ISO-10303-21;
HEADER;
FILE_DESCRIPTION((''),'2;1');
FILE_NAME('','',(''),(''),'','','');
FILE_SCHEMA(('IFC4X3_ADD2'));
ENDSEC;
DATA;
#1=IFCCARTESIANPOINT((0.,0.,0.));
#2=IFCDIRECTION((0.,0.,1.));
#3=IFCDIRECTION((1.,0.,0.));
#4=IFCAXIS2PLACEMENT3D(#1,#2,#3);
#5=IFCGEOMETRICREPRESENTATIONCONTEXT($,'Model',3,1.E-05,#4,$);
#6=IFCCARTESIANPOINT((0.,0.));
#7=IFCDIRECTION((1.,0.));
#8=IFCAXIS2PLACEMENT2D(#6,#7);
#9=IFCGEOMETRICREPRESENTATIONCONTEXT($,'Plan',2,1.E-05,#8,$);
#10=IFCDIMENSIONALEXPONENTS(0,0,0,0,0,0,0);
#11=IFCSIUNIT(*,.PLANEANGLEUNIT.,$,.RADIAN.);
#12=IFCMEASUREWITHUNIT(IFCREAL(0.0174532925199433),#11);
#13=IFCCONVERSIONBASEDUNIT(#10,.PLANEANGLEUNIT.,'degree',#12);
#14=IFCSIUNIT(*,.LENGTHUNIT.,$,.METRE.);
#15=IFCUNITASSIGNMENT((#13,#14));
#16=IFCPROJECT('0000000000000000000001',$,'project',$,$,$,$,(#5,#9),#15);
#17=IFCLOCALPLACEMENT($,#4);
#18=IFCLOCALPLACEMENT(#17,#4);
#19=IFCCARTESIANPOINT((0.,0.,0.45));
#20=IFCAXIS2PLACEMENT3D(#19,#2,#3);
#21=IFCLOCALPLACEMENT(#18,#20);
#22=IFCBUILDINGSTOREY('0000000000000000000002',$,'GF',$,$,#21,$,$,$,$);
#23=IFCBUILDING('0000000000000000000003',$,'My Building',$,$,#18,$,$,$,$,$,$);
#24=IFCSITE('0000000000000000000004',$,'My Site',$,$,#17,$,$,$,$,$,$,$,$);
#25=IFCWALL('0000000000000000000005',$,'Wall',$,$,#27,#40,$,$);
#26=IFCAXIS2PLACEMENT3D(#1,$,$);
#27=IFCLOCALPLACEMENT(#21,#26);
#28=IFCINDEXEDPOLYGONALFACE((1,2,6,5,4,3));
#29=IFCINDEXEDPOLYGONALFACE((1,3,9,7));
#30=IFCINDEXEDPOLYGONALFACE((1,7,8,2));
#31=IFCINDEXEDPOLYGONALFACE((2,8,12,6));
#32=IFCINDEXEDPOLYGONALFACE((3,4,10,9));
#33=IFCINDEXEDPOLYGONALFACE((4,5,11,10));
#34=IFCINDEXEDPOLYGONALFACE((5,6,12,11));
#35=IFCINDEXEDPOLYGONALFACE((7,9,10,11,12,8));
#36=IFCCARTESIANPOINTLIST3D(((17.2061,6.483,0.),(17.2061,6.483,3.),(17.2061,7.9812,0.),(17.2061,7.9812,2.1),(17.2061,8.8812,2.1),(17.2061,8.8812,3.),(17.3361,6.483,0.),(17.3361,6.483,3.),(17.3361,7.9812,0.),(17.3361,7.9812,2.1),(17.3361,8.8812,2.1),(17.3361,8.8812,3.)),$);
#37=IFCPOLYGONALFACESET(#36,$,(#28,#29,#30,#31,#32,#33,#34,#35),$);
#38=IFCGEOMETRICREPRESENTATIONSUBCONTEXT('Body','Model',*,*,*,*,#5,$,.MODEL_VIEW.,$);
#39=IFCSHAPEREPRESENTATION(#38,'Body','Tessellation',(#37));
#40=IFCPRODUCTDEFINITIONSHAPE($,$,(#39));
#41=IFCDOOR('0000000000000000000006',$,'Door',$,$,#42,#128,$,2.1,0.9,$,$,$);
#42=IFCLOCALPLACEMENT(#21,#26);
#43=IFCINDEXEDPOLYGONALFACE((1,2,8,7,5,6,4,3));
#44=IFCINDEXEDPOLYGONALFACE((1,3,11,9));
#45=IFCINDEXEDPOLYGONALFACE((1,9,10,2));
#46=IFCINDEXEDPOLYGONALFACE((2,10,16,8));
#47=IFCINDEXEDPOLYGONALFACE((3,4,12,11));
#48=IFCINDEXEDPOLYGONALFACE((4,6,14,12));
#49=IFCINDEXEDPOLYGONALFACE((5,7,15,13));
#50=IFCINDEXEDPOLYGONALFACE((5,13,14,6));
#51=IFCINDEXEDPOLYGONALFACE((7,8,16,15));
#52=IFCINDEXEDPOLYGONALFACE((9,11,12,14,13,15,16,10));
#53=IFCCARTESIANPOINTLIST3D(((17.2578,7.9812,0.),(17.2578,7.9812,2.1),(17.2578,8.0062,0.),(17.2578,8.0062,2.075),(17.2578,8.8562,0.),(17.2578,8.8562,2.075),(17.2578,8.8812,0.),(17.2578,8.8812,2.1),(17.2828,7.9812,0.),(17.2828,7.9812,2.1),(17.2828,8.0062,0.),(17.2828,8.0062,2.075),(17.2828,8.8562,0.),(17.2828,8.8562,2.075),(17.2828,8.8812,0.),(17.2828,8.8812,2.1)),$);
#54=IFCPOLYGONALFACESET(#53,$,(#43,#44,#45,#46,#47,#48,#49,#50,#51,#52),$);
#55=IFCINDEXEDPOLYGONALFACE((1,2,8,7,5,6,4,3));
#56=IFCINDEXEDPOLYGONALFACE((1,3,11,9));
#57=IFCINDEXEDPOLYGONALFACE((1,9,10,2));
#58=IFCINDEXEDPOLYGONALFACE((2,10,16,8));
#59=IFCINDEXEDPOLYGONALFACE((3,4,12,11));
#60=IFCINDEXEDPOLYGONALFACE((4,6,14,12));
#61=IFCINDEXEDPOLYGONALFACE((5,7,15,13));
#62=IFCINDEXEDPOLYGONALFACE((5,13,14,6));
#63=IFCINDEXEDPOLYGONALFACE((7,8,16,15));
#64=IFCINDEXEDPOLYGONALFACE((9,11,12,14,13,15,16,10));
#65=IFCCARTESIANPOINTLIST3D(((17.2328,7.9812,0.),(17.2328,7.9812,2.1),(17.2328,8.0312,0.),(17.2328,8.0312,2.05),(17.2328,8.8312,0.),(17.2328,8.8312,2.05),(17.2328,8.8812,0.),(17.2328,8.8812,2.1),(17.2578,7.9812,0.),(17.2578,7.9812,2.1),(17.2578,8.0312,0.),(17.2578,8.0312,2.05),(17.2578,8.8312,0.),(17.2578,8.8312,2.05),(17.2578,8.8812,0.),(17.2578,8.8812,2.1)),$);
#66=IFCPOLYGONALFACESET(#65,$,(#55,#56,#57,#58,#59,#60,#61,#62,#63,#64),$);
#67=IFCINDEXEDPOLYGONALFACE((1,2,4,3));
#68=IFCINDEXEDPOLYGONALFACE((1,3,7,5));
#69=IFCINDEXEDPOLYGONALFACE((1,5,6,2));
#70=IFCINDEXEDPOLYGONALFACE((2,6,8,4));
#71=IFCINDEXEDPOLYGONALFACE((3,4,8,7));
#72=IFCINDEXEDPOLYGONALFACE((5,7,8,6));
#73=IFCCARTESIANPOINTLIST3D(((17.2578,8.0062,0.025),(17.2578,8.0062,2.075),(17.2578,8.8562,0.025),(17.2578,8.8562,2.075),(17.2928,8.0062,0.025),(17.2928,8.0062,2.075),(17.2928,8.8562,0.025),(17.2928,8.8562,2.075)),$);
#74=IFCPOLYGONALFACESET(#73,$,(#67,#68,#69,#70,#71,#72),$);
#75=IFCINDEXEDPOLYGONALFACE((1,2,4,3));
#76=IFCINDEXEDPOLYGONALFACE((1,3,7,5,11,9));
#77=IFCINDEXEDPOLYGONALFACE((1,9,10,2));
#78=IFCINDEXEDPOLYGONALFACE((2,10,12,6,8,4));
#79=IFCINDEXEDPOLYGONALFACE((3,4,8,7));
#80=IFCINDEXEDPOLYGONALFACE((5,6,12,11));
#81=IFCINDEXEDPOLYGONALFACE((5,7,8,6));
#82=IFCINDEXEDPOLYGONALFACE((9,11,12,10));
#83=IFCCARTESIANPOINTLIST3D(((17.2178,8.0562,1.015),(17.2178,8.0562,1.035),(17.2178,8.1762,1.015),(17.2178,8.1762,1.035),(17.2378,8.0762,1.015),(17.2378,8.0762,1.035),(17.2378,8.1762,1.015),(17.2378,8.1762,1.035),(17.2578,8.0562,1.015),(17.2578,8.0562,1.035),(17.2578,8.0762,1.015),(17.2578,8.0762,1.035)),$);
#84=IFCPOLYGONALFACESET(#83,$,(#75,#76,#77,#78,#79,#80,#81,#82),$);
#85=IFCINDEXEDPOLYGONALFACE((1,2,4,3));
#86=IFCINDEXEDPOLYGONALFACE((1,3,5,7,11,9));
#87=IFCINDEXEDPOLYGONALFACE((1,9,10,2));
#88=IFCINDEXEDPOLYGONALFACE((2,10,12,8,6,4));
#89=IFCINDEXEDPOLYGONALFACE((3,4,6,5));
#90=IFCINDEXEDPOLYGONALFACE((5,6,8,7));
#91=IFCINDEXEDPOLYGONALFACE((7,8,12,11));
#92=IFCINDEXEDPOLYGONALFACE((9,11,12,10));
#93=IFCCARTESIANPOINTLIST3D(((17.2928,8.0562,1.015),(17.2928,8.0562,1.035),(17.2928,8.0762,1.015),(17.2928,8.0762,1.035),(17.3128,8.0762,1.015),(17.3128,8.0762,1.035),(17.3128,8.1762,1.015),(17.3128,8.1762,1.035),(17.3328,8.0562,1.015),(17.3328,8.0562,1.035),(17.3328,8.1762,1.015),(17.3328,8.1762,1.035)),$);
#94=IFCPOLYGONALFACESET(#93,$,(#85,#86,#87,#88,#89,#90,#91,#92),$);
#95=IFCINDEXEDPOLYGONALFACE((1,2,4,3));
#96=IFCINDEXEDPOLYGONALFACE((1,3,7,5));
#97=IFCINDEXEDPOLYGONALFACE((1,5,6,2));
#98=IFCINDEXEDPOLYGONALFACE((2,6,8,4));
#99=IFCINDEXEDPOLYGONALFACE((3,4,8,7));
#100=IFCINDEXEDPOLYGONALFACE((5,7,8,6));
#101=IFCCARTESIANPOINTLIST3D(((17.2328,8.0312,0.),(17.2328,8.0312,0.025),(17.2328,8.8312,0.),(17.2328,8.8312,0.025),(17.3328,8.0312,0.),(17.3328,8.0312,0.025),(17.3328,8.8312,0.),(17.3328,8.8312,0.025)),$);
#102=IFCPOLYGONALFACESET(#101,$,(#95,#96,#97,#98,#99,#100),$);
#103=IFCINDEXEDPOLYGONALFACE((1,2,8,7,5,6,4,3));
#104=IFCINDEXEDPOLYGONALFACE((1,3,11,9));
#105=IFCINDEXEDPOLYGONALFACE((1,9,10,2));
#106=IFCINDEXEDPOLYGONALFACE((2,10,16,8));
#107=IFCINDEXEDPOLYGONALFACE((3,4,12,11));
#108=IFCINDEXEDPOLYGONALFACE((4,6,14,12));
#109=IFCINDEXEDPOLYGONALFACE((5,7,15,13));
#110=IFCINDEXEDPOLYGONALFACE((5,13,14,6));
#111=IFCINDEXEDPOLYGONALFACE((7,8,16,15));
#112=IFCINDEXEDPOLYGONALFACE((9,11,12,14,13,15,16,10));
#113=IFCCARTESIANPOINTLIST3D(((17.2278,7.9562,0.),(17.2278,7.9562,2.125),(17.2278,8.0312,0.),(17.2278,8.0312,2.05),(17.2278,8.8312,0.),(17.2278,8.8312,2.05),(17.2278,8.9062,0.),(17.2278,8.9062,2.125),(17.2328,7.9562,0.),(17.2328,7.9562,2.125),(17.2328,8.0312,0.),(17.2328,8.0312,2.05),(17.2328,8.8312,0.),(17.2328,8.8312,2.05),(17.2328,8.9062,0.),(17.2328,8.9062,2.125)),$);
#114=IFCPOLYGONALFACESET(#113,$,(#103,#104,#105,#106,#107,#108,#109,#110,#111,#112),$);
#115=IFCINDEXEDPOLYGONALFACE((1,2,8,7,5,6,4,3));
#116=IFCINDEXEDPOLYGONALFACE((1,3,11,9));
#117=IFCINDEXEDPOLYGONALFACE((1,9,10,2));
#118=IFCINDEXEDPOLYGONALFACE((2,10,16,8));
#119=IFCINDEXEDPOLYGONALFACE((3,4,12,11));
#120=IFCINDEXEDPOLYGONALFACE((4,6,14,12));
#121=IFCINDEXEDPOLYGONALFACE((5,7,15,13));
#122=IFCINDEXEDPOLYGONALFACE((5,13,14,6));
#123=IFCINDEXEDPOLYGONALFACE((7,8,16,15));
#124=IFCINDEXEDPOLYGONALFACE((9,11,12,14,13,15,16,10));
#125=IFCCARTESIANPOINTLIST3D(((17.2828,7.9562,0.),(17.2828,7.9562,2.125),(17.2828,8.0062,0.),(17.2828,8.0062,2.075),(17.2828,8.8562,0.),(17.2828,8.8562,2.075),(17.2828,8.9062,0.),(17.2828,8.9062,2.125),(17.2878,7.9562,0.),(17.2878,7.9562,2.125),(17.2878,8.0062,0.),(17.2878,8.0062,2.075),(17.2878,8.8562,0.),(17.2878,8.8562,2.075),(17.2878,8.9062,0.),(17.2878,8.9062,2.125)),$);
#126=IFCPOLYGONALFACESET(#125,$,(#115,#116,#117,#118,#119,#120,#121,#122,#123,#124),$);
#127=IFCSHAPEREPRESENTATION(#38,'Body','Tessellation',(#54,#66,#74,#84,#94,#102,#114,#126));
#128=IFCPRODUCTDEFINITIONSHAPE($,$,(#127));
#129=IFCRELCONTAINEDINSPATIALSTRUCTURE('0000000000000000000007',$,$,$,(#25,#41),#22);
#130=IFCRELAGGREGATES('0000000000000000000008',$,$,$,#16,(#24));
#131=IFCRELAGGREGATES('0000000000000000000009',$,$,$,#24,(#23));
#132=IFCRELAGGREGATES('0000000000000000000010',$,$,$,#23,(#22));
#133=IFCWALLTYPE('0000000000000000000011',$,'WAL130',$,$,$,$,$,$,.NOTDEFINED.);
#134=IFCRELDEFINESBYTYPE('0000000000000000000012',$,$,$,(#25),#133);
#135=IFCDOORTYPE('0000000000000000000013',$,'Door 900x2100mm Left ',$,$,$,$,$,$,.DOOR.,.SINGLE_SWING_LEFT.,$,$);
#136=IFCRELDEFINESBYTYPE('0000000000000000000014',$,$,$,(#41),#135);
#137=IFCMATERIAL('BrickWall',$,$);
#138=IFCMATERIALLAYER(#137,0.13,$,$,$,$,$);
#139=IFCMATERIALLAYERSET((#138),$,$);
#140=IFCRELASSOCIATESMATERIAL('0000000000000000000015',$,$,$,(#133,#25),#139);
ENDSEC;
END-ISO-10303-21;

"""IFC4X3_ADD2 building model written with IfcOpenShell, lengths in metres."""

from ifc_helpers import new_model, entity, si_unit, converted_unit, frame, origin_with_axes, origin_2d_with_axis, place, context, subcontext, project, spatial, line, indexed_curve, outline, extrude, shape, source, transform, mapped, material, layer, layer_set, layer_usage, type_object, type_shapes, element, fill, save


model = new_model("IFC4X3_ADD2")

# Units and contexts
model_context = context("Model", 3, precision=1e-05, world=origin_with_axes())
plan_context = context("Plan", 2, precision=1e-05, world=origin_2d_with_axis())
body_context_1 = subcontext(model_context, "Body", "Model", "MODEL_VIEW")
body_context_2 = subcontext(plan_context, "Body", "Plan", "PLAN_VIEW")
ifc_project = project(units=[converted_unit("PLANEANGLEUNIT", "degree", entity("IfcReal", 0.0174532925199433), si_unit("PLANEANGLEUNIT", "RADIAN"), dimensions=[0, 0, 0, 0, 0, 0, 0]), si_unit("LENGTHUNIT", "METRE")], contexts=[model_context, plan_context])

# Site, building, storey
site_placement = place(None, origin_with_axes())
site = spatial("IfcSite", under=ifc_project, at=site_placement, Name="My Site")
building_placement = place(site_placement, origin_with_axes())
building = spatial("IfcBuilding", under=site, at=building_placement, Name="My Building")
storey_placement = place(building_placement, frame((0.0, 0.0, 0.45), z_axis=(0.0, 0.0, 1.0), x_axis=(1.0, 0.0, 0.0)))
storey = spatial("IfcBuildingStorey", under=building, at=storey_placement, Name="GF")

# Shared definitions
ifc_material_1 = material(Name="BrickWall")

# Wall, opening, door
ifc_layer_1 = layer(ifc_material_1, 0.13)
ifc_layer_set_1 = layer_set([ifc_layer_1])
wall_type_1 = type_object("IfcWallType", Name="WAL130", PredefinedType="NOTDEFINED", material=ifc_layer_set_1)
ifc_layer_usage_1 = layer_usage(ifc_layer_set_1, "AXIS2", "POSITIVE", 0.0)
wall_1_placement = place(storey_placement, frame((17.3361, 6.483, 0.0), z_axis=(0.0, 0.0, 1.0), x_axis=(0.0, 1.0, 0.0)))
wall_1 = element("IfcWall", 1, at=wall_1_placement, inside=storey, type_object=wall_type_1, material=ifc_layer_usage_1, Name="Wall", context=body_context_1, shape_type="SweptSolid", body=[
    extrude(outline(indexed_curve([(0.0, 0.0), (0.0, 0.13), (2.3981, 0.13), (2.3981, 0.0), (0.0, 0.0)], self_intersect=False)), origin_with_axes(), (0.0, 0.0, 1.0), 3.0),
])
shared_shape_1 = source(origin_with_axes(), body_context_1, "Body", "SweptSolid", [
    extrude(outline(indexed_curve([(0.0, 0.0), (0.9, 0.0), (0.9, 2.1), (0.0, 2.1)], segments=[line(1, 2, 3, 4, 1)])), frame((0.0, -0.6, 0.0), z_axis=(0.0, -1.0, 0.0), x_axis=(1.0, 0.0, 0.0)), (0.0, 0.0, -1.0), 1.2),
])
opening_1_placement = place(wall_1_placement, frame((2.3981, 0.1033, 0.0), z_axis=(0.0, 0.0, 1.0), x_axis=(-1.0, 0.0, 0.0)))
opening_1 = element("IfcOpeningElement", 2, at=opening_1_placement, cuts=wall_1, PredefinedType="OPENING", context=body_context_1, shape_type="MappedRepresentation", body=[
    mapped(shared_shape_1, transform((0.0, 0.0, 0.0), x_axis=(1.0, 0.0, 0.0), y_axis=(0.0, 1.0, 0.0), z_axis=(0.0, 0.0, 1.0), scale=1.0)),
])
door_type_1 = type_object("IfcDoorType", Name="Door 900x2100mm Left ", OperationType="SINGLE_SWING_LEFT", PredefinedType="DOOR")
shared_shape_2 = source(origin_with_axes(), body_context_1, "Body", "SweptSolid", [
    extrude(outline(indexed_curve([(0.0, 0.0), (0.0, 2.1), (0.9, 2.1), (0.9, 0.0), (0.875, 0.0), (0.875, 2.075), (0.025, 2.075), (0.025, 0.0)], segments=[line(1, 2, 3, 4, 5, 6, 7, 8, 1)])), frame((0.0, 0.025, 0.0), z_axis=(0.0, -1.0, 0.0), x_axis=(1.0, 0.0, 0.0)), (0.0, 0.0, -1.0), 0.025),
    extrude(outline(indexed_curve([(0.0, 0.0), (0.0, 2.1), (0.9, 2.1), (0.9, 0.0), (0.85, 0.0), (0.85, 2.05), (0.05, 2.05), (0.05, 0.0)], segments=[line(1, 2, 3, 4, 5, 6, 7, 8, 1)])), frame((0.0, 0.0, 0.0), z_axis=(0.0, -1.0, 0.0), x_axis=(1.0, 0.0, 0.0)), (0.0, 0.0, -1.0), 0.025),
    extrude(outline(indexed_curve([(0.0, 0.0), (0.85, 0.0), (0.85, 0.035), (0.0, 0.035)], segments=[line(1, 2, 3, 4, 1)])), frame((0.025, 0.025, 0.025), z_axis=(0.0, 0.0, 1.0), x_axis=(1.0, 0.0, 0.0)), (0.0, 0.0, 1.0), 2.05),
    extrude(outline(indexed_curve([(0.0, 0.0), (0.0, -0.04), (-0.12, -0.04), (-0.12, -0.02), (-0.02, -0.02), (-0.02, 0.0)], segments=[line(1, 2, 3, 4, 5, 6, 1)])), frame((0.825, 0.025, 1.015), z_axis=(0.0, 0.0, 1.0), x_axis=(1.0, 0.0, 0.0)), (0.0, 0.0, 1.0), 0.02),
    extrude(outline(indexed_curve([(0.0, 0.0), (0.0, 0.04), (-0.12, 0.04), (-0.12, 0.02), (-0.02, 0.02), (-0.02, 0.0)], segments=[line(1, 2, 3, 4, 5, 6, 1)])), frame((0.825, 0.06, 1.015), z_axis=(0.0, 0.0, 1.0), x_axis=(1.0, 0.0, 0.0)), (0.0, 0.0, 1.0), 0.02),
    extrude(outline(indexed_curve([(0.0, 0.0), (0.8, 0.0), (0.8, 0.1), (0.0, 0.1)], segments=[line(1, 2, 3, 4, 1)])), frame((0.05, 0.0, 0.0), z_axis=(0.0, 0.0, 1.0), x_axis=(1.0, 0.0, 0.0)), (0.0, 0.0, 1.0), 0.025),
    extrude(outline(indexed_curve([(0.0, 0.0), (0.0, 2.125), (0.95, 2.125), (0.95, 0.0), (0.875, 0.0), (0.875, 2.05), (0.075, 2.05), (0.075, 0.0)], segments=[line(1, 2, 3, 4, 5, 6, 7, 8, 1)])), frame((-0.025, -0.005, 0.0), z_axis=(0.0, -1.0, 0.0), x_axis=(1.0, 0.0, 0.0)), (0.0, 0.0, -1.0), 0.005),
    extrude(outline(indexed_curve([(0.0, 0.0), (0.0, 2.125), (0.95, 2.125), (0.95, 0.0), (0.9, 0.0), (0.9, 2.075), (0.05, 2.075), (0.05, 0.0)], segments=[line(1, 2, 3, 4, 5, 6, 7, 8, 1)])), frame((-0.025, 0.05, 0.0), z_axis=(0.0, -1.0, 0.0), x_axis=(1.0, 0.0, 0.0)), (0.0, 0.0, -1.0), 0.005),
])
shared_shape_3 = source(origin_with_axes(), body_context_2, "Body", "Curve2D", [
    entity("IfcIndexedPolyCurve", entity("IfcCartesianPointList2D", [[0.0, 0.0], [0.0, 0.05], [0.025, 0.05], [0.025, 0.025], [0.05, 0.025], [0.05, 0.0]]), [entity("IfcLineIndex", [1, 2, 3, 4, 5, 6, 1])]),
    entity("IfcIndexedPolyCurve", entity("IfcCartesianPointList2D", [[0.9, 0.0], [0.9, 0.05], [0.875, 0.05], [0.875, 0.025], [0.85, 0.025], [0.85, 0.0]]), [entity("IfcLineIndex", [1, 2, 3, 4, 5, 6, 1])]),
    entity("IfcTrimmedCurve", entity("IfcEllipse", entity("IfcAxis2Placement2D", entity("IfcCartesianPoint", [0.06, 0.05]), entity("IfcDirection", [1.0, 0.0])), 0.815, 0.85), [entity("IfcCartesianPoint", [0.875, 0.05])], [entity("IfcCartesianPoint", [0.06, 0.9])], True, "CARTESIAN"),
    entity("IfcIndexedPolyCurve", entity("IfcCartesianPointList2D", [[0.025, 0.05], [0.06, 0.05], [0.06, 0.9], [0.025, 0.9]]), [entity("IfcLineIndex", [1, 2, 3, 4, 1])]),
])
type_shapes(door_type_1, [shared_shape_2, shared_shape_3])
door_1_placement = place(opening_1_placement, frame((0.0, 0.0, 0.0), z_axis=(0.0, 0.0, 1.0), x_axis=(1.0, 0.0, 0.0)))
door_1 = element("IfcDoor", 3, at=door_1_placement, inside=storey, type_object=door_type_1, Name="Door", OverallHeight=2.1, OverallWidth=0.9, shapes=[
    shape(body_context_1, "Body", "MappedRepresentation", [mapped(shared_shape_2, transform((0.0, 0.0, 0.0), x_axis=(1.0, 0.0, 0.0), y_axis=(0.0, 1.0, 0.0), z_axis=(0.0, 0.0, 1.0), scale=1.0))]),
    shape(body_context_2, "Body", "MappedRepresentation", [mapped(shared_shape_3, transform((0.0, 0.0, 0.0), x_axis=(1.0, 0.0, 0.0), y_axis=(0.0, 1.0, 0.0), z_axis=(0.0, 0.0, 1.0), scale=1.0))]),
])
fill(opening_1, door_1)

save(model, "model.ifc")
